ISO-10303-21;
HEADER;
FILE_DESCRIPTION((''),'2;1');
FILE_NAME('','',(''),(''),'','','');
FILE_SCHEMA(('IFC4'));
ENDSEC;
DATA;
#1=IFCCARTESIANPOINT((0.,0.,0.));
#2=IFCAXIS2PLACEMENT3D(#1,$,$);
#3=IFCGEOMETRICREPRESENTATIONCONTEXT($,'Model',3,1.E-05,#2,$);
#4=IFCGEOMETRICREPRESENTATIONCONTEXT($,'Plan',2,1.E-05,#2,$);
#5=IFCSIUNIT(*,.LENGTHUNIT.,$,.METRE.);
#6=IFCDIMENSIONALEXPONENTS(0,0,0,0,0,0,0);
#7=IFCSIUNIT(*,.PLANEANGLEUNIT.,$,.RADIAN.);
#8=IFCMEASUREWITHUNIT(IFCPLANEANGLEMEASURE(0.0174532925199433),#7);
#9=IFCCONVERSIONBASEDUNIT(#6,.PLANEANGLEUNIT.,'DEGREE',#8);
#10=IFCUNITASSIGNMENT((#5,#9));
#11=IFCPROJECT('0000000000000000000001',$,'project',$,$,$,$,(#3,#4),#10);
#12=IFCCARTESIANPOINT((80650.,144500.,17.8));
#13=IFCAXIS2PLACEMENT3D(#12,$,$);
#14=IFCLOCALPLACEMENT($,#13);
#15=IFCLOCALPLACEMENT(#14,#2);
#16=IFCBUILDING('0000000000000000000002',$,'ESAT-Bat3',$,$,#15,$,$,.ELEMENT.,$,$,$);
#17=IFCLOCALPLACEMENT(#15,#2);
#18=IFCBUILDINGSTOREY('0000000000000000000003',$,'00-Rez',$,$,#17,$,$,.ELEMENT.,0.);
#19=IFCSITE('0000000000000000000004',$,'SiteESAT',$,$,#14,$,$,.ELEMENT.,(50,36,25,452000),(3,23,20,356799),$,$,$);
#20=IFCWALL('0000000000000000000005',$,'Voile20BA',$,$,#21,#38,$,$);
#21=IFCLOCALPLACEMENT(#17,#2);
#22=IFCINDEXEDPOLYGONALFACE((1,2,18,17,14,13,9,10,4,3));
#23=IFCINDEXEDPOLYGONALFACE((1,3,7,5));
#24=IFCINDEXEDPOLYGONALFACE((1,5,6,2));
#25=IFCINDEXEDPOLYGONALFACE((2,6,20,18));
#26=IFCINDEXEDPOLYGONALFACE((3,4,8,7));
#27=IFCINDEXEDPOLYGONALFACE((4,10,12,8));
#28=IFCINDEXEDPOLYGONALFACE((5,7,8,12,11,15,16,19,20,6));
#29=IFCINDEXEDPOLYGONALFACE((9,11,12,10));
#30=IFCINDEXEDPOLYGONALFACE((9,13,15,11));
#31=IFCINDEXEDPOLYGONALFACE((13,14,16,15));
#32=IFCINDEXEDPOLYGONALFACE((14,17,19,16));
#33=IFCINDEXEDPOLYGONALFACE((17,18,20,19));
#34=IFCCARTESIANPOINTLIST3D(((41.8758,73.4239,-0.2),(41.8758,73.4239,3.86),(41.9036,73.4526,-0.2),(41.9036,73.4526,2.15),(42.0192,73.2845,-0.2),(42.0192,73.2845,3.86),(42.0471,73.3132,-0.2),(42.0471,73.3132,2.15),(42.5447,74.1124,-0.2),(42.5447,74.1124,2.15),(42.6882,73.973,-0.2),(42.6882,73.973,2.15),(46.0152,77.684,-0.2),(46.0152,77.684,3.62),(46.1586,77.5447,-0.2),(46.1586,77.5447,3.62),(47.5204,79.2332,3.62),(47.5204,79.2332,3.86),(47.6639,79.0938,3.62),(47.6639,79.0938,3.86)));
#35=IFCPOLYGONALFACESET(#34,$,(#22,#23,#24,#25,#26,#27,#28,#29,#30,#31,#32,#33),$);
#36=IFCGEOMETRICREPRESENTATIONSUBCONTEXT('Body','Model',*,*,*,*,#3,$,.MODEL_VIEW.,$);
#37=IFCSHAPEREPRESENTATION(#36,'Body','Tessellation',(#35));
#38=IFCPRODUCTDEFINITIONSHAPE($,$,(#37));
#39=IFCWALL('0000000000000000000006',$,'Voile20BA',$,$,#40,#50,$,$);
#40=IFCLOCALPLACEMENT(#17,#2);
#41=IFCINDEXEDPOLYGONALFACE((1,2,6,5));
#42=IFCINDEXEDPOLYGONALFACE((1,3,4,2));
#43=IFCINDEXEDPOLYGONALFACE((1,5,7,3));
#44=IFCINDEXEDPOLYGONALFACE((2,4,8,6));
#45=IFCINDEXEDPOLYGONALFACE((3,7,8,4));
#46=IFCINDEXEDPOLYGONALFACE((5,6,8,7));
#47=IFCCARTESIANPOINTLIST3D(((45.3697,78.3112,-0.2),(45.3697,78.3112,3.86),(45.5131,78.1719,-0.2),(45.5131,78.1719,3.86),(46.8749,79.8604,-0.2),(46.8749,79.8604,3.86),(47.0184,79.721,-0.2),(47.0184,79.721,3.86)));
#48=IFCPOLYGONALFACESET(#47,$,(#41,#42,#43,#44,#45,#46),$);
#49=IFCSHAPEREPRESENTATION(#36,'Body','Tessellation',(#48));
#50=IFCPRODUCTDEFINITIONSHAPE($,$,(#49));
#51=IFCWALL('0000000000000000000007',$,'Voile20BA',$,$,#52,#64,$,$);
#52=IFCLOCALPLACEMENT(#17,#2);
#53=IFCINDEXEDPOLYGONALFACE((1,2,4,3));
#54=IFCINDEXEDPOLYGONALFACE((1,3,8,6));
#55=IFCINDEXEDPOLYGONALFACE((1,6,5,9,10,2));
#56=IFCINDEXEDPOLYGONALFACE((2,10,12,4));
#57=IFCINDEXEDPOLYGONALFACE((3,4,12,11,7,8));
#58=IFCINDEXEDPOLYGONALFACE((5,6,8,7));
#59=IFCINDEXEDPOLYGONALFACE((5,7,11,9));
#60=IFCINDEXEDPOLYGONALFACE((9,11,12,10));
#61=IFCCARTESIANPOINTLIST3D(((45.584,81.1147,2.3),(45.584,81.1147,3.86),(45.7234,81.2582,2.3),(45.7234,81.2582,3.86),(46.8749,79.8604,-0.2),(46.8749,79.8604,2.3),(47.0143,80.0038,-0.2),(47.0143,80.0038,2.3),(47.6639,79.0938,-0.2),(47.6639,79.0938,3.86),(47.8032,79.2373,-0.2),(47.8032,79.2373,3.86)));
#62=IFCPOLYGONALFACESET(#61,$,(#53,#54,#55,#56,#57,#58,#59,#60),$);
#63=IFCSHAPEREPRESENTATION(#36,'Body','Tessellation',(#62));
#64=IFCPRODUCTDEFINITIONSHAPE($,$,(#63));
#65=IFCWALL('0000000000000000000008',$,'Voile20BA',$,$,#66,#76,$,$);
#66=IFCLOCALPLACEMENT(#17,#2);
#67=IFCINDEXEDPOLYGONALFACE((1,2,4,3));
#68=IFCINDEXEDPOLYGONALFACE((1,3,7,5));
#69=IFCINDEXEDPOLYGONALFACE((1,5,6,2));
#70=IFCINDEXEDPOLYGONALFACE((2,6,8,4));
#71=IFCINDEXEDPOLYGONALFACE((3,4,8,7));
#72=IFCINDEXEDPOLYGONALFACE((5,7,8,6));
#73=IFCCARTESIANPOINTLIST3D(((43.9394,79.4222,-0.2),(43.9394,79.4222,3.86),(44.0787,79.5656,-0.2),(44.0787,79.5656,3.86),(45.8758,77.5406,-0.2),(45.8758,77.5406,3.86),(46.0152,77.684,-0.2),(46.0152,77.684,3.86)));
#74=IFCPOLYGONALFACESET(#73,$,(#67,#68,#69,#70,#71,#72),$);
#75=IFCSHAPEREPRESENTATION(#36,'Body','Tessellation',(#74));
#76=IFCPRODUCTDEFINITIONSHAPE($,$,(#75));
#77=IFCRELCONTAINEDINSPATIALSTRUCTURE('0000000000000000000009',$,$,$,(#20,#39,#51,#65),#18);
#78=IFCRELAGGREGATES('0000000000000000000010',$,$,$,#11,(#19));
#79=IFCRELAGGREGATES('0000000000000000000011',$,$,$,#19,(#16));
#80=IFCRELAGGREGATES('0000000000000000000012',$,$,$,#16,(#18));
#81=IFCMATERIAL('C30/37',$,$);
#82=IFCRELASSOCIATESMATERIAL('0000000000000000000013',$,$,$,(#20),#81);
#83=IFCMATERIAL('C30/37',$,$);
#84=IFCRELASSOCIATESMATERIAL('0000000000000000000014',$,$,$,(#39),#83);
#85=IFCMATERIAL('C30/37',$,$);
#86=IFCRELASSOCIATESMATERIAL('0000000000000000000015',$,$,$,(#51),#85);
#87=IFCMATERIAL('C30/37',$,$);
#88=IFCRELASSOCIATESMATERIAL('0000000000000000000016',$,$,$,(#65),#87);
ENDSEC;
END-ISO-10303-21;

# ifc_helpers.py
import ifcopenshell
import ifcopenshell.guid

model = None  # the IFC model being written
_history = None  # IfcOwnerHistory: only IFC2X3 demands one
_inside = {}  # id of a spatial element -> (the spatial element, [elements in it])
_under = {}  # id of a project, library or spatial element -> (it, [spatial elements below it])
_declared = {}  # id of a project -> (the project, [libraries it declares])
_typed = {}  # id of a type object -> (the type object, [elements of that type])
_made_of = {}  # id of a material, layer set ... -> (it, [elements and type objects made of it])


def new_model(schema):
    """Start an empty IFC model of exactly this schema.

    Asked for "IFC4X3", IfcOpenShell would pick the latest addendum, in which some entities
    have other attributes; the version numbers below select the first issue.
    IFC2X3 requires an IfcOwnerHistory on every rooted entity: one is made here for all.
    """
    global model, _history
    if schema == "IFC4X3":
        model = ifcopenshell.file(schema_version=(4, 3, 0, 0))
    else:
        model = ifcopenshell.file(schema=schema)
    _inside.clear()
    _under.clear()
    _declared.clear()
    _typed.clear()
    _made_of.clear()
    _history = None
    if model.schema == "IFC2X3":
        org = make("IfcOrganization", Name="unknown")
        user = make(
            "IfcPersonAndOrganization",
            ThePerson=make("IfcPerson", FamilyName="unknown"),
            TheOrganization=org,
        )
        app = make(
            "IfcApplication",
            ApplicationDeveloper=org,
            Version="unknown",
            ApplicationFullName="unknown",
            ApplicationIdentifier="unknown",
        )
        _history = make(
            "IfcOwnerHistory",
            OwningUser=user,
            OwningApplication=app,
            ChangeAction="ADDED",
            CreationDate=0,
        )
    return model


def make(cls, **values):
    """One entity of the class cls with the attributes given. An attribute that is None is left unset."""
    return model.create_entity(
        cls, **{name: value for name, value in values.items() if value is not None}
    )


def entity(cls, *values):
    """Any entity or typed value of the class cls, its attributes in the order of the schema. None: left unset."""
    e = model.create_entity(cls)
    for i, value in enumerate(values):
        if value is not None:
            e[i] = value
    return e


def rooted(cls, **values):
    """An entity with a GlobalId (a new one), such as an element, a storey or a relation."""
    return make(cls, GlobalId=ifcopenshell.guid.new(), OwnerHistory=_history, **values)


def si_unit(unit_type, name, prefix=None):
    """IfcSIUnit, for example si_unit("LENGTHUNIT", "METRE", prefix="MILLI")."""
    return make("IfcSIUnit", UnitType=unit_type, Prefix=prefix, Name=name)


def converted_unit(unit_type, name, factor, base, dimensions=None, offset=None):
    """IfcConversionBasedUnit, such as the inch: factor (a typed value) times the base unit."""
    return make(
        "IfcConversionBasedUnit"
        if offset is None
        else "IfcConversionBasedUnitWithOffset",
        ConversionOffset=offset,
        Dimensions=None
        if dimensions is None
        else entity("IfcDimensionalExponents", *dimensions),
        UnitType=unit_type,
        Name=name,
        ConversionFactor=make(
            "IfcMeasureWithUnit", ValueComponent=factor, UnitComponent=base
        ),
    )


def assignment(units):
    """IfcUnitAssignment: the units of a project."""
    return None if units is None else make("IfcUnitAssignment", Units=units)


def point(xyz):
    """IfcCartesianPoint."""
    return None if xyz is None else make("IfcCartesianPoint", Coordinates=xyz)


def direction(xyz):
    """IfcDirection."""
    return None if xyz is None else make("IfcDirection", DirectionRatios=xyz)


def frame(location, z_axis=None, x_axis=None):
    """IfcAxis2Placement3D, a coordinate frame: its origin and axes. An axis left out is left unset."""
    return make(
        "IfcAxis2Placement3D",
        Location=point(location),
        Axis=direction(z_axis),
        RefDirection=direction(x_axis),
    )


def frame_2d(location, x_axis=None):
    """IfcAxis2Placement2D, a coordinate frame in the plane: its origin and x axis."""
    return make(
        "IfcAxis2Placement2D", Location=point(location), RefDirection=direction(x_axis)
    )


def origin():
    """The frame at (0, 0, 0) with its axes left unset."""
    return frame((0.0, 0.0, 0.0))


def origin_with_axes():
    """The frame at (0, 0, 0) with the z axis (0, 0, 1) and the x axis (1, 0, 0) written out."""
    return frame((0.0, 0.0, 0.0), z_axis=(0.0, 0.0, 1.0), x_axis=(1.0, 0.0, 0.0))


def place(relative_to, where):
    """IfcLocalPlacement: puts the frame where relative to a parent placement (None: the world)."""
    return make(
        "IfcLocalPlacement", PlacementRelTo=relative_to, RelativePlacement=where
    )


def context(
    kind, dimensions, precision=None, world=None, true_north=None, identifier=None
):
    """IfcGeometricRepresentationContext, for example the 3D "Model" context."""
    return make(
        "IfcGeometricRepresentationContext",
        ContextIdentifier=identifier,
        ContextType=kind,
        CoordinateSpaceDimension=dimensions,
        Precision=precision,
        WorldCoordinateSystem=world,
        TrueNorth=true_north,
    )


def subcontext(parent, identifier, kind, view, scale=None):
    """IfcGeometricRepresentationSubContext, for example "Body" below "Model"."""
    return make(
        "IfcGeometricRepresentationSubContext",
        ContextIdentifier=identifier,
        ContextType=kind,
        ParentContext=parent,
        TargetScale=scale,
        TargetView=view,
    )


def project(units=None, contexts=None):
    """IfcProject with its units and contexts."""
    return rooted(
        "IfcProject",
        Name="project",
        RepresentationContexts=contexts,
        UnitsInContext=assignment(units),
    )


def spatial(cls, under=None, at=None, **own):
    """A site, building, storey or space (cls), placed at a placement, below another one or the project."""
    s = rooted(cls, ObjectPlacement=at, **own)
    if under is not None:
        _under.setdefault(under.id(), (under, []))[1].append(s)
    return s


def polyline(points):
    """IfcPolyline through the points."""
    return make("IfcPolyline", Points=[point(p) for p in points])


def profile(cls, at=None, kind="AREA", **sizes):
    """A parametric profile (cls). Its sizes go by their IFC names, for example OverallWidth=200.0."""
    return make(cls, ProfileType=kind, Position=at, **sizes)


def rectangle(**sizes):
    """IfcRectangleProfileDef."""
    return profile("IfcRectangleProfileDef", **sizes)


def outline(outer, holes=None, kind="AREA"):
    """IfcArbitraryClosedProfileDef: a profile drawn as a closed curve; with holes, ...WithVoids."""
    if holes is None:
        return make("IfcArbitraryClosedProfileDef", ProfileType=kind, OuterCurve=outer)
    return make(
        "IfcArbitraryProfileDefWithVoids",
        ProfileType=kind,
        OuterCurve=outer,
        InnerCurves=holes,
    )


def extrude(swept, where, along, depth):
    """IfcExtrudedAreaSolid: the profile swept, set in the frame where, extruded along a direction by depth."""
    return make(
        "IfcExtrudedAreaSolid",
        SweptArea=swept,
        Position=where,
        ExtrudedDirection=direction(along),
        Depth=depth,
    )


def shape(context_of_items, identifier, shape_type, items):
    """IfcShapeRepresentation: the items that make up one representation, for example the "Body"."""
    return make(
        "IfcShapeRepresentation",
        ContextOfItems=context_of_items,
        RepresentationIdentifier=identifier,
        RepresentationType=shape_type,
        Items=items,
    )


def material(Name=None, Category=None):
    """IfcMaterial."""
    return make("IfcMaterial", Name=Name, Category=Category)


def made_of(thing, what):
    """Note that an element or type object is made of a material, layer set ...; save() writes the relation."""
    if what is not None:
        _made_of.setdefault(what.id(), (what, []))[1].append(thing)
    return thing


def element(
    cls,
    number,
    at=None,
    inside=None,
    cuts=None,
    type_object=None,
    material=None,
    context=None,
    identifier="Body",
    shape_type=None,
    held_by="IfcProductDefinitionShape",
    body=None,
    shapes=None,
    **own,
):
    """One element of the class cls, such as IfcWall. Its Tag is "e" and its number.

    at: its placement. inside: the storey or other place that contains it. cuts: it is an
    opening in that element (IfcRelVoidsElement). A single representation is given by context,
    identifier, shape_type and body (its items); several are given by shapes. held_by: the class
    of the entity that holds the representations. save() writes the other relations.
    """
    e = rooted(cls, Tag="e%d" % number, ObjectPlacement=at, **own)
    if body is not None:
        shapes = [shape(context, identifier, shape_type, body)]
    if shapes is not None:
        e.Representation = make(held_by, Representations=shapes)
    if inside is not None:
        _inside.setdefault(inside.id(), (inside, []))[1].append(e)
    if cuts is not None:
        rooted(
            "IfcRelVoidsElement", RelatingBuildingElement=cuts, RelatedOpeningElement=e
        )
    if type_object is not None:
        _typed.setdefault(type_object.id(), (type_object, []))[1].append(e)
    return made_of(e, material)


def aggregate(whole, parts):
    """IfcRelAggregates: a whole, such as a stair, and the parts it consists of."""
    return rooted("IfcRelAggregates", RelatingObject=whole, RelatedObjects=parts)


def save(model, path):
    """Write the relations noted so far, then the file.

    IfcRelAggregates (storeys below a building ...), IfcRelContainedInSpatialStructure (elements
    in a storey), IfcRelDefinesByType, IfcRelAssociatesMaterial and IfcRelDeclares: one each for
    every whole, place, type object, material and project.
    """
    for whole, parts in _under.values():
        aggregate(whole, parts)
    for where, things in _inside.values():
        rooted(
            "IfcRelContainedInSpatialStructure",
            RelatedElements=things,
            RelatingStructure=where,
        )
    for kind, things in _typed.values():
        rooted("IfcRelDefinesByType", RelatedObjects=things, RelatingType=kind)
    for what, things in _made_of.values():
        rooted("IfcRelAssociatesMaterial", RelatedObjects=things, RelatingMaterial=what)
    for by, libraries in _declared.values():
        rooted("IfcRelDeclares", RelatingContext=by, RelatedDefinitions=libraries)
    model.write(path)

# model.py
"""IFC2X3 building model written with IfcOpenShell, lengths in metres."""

from ifc_helpers import new_model, entity, si_unit, converted_unit, frame, frame_2d, origin, origin_with_axes, place, context, subcontext, project, spatial, polyline, rectangle, outline, extrude, material, element, save


model = new_model("IFC2X3")

# Units and contexts
model_context = context("Model", 3, precision=1e-05, world=origin())
plan_context = context("Plan", 2, precision=1e-05, world=origin())
body_context = subcontext(model_context, "Body", "Model", "MODEL_VIEW")
ifc_project = project(units=[si_unit("LENGTHUNIT", "METRE"), converted_unit("PLANEANGLEUNIT", "DEGREE", entity("IfcPlaneAngleMeasure", 0.0174532925199433), si_unit("PLANEANGLEUNIT", "RADIAN"), dimensions=[0, 0, 0, 0, 0, 0, 0])], contexts=[model_context, plan_context])

# Site, building, storey
site_placement = place(None, frame((80650.0, 144500.0, 17.8)))
site = spatial("IfcSite", under=ifc_project, at=site_placement, Name="SiteESAT", CompositionType="ELEMENT", RefLatitude=(50, 36, 25, 452000), RefLongitude=(3, 23, 20, 356799))
building_placement = place(site_placement, origin())
building = spatial("IfcBuilding", under=site, at=building_placement, Name="ESAT-Bat3", CompositionType="ELEMENT")
storey_placement = place(building_placement, origin())
storey = spatial("IfcBuildingStorey", under=building, at=storey_placement, Name="00-Rez", CompositionType="ELEMENT", Elevation=0.0)

# Wall, openings
ifc_material_1 = material(Name="C30/37")
wall_1_placement = place(storey_placement, frame((47.5204, 79.2332, -0.2), z_axis=(0.0, 0.0, 1.0), x_axis=(-0.696872, -0.717196, 0.0)))
wall_1 = element("IfcWall", 1, at=wall_1_placement, inside=storey, material=ifc_material_1, Name="Voile20BA", context=body_context, shape_type="SweptSolid", body=[
    extrude(rectangle(XDim=8.1, YDim=0.2, at=frame_2d((4.05, 0.1), x_axis=(1.0, 0.0))), origin_with_axes(), (0.0, 0.0, 1.0), 4.06),
])
opening_1_placement = place(wall_1_placement, frame((2.16, 0.2, 0.0), z_axis=(0.0, -1.0, 0.0), x_axis=(0.0, 0.0, 1.0)))
element("IfcOpeningElement", 2, at=opening_1_placement, cuts=wall_1, ObjectType="Opening", context=body_context, shape_type="SweptSolid", body=[
    extrude(outline(polyline([(0.0, 2.16), (3.82, 2.16), (3.82, 0.0), (0.0, 0.0), (0.0, 2.16)])), origin_with_axes(), (0.0, 0.0, 1.0), 0.2),
])
opening_2_placement = place(wall_1_placement, frame((8.06, 0.2, 0.0), z_axis=(0.0, -1.0, 0.0), x_axis=(0.0, 0.0, 1.0)))
element("IfcOpeningElement", 3, at=opening_2_placement, cuts=wall_1, ObjectType="Opening", context=body_context, shape_type="SweptSolid", body=[
    extrude(outline(polyline([(0.0, 0.92), (2.35, 0.92), (2.35, 0.0), (0.0, 0.0), (0.0, 0.92)])), origin_with_axes(), (0.0, 0.0, 1.0), 0.2),
])

# Wall
ifc_material_2 = material(Name="C30/37")
wall_2_placement = place(storey_placement, frame((45.5131, 78.1719, -0.2), z_axis=(0.0, 0.0, 1.0), x_axis=(0.696872, 0.717196, 0.0)))
element("IfcWall", 4, at=wall_2_placement, inside=storey, material=ifc_material_2, Name="Voile20BA", context=body_context, shape_type="SweptSolid", body=[
    extrude(rectangle(XDim=2.16, YDim=0.2, at=frame_2d((1.08, 0.1), x_axis=(1.0, 0.0))), origin_with_axes(), (0.0, 0.0, 1.0), 4.06),
])

# Wall, opening
ifc_material_3 = material(Name="C30/37")
wall_3_placement = place(storey_placement, frame((45.584, 81.1147, -0.2), z_axis=(0.0, 0.0, 1.0), x_axis=(0.717196, -0.696872, 0.0)))
wall_3 = element("IfcWall", 5, at=wall_3_placement, inside=storey, material=ifc_material_3, Name="Voile20BA", context=body_context, shape_type="SweptSolid", body=[
    extrude(rectangle(XDim=2.9, YDim=0.2, at=frame_2d((1.45, 0.1), x_axis=(1.0, 0.0))), origin_with_axes(), (0.0, 0.0, 1.0), 4.06),
])
opening_3_placement = place(wall_3_placement, frame((1.8, 0.2, 0.0), z_axis=(0.0, -1.0, 0.0), x_axis=(0.0, 0.0, 1.0)))
element("IfcOpeningElement", 6, at=opening_3_placement, cuts=wall_3, ObjectType="Opening", context=body_context, shape_type="SweptSolid", body=[
    extrude(outline(polyline([(0.0, 1.8), (2.5, 1.8), (2.5, 0.0), (0.0, 0.0), (0.0, 1.8)])), origin_with_axes(), (0.0, 0.0, 1.0), 0.2),
])

# Wall
ifc_material_4 = material(Name="C30/37")
wall_4_placement = place(storey_placement, frame((46.0152, 77.684, -0.2), z_axis=(0.0, 0.0, 1.0), x_axis=(-0.717196, 0.696872, 0.0)))
element("IfcWall", 7, at=wall_4_placement, inside=storey, material=ifc_material_4, Name="Voile20BA", context=body_context, shape_type="SweptSolid", body=[
    extrude(rectangle(XDim=2.7, YDim=0.2, at=frame_2d((1.35, 0.1), x_axis=(1.0, 0.0))), origin_with_axes(), (0.0, 0.0, 1.0), 4.06),
])

save(model, "model.ifc")
